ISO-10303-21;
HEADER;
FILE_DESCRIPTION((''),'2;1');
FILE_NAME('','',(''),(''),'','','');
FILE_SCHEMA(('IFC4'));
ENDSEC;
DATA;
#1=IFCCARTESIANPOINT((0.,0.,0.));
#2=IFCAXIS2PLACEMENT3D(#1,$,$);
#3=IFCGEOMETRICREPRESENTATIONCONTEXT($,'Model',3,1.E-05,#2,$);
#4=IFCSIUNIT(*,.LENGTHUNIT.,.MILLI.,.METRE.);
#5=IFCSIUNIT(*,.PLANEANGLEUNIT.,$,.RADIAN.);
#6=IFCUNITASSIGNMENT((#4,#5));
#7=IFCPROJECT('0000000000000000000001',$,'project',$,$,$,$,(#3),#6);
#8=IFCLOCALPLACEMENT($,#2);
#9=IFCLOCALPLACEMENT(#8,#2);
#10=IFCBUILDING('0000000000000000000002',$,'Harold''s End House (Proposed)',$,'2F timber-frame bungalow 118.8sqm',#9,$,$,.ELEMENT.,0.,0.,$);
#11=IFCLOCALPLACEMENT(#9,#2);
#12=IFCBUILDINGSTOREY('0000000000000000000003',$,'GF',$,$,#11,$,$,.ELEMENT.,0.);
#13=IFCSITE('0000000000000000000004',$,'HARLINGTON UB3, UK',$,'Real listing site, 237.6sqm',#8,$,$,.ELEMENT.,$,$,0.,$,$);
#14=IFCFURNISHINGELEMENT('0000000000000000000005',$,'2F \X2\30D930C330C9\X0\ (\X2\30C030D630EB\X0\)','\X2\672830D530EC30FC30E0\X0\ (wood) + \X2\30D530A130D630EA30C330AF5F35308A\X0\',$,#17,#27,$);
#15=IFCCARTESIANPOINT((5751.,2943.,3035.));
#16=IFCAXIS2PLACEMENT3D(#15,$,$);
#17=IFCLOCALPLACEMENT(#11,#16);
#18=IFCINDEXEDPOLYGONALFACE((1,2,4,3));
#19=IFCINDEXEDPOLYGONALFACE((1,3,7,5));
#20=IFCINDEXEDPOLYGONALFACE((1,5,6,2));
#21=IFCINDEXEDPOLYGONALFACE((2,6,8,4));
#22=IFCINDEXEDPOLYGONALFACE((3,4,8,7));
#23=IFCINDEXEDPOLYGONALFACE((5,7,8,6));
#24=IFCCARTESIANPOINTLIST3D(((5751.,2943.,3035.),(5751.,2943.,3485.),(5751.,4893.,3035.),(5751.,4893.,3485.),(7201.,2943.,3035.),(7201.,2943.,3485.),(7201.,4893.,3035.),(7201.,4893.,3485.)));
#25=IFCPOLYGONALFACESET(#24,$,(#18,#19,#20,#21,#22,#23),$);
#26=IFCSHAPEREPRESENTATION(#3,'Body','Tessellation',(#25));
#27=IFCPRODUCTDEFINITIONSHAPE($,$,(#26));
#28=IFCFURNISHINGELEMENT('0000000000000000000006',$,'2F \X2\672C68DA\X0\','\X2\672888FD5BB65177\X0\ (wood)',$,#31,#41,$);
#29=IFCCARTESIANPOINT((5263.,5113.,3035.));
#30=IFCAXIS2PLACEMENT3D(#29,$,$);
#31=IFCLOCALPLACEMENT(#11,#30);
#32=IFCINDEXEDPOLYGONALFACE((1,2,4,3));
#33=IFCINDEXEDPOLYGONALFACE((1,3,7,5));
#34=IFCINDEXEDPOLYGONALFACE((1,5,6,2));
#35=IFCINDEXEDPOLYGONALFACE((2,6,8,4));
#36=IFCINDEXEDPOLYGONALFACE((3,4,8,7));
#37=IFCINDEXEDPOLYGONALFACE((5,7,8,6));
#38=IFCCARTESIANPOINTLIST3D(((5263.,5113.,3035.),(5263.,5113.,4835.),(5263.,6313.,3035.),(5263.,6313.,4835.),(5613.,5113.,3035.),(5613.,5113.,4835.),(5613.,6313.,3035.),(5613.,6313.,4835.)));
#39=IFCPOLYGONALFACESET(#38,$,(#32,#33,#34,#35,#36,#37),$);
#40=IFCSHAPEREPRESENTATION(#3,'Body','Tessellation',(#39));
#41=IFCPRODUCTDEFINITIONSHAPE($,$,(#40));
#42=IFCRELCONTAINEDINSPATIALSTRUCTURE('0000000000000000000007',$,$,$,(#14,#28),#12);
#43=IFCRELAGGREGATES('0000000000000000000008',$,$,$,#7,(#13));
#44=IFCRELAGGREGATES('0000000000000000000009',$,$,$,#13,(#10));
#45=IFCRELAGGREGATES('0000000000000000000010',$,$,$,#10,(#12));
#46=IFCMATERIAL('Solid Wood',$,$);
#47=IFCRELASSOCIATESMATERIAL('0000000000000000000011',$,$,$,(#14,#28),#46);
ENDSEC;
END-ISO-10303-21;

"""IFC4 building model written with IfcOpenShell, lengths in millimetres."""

from ifc_helpers import new_model, si_unit, frame, frame_2d, origin, place, context, project, spatial, rectangle, extrude, material, element, save


model = new_model("IFC4")

# Units and contexts
model_context = context("Model", 3, precision=1e-05, world=origin())
ifc_project = project(units=[si_unit("LENGTHUNIT", "METRE", prefix="MILLI"), si_unit("PLANEANGLEUNIT", "RADIAN")], contexts=[model_context])

# Site, building, storey
site_placement = place(None, origin())
site = spatial("IfcSite", under=ifc_project, at=site_placement, Name="HARLINGTON UB3, UK", ObjectType="Real listing site, 237.6sqm", CompositionType="ELEMENT", RefElevation=0.0)
building_placement = place(site_placement, origin())
building = spatial("IfcBuilding", under=site, at=building_placement, Name="Harold's End House (Proposed)", ObjectType="2F timber-frame bungalow 118.8sqm", CompositionType="ELEMENT", ElevationOfRefHeight=0.0, ElevationOfTerrain=0.0)
storey_placement = place(building_placement, origin())
storey = spatial("IfcBuildingStorey", under=building, at=storey_placement, Name="GF", CompositionType="ELEMENT", Elevation=0.0)

# Shared definitions
ifc_material_1 = material(Name="Solid Wood")

# Furnishing elements
furnishing_1_placement = place(storey_placement, frame((5751.0, 2943.0, 3035.0)))
element("IfcFurnishingElement", 1, at=furnishing_1_placement, inside=storey, material=ifc_material_1, Name="2F ベッド (ダブル)", Description="木フレーム (wood) + ファブリック張り", context=model_context, shape_type="SweptSolid", body=[
    extrude(rectangle(XDim=1450.0, YDim=1950.0, at=frame_2d((725.0, 975.0))), frame((5751.0, 2943.0, 3035.0)), (0.0, 0.0, 1.0), 450.0),
])
furnishing_2_placement = place(storey_placement, frame((5263.0, 5113.0, 3035.0)))
element("IfcFurnishingElement", 2, at=furnishing_2_placement, inside=storey, material=ifc_material_1, Name="2F 本棚", Description="木製家具 (wood)", context=model_context, shape_type="SweptSolid", body=[
    extrude(rectangle(XDim=350.0, YDim=1200.0, at=frame_2d((175.0, 600.0))), frame((5263.0, 5113.0, 3035.0)), (0.0, 0.0, 1.0), 1800.0),
])

save(model, "model.ifc")
